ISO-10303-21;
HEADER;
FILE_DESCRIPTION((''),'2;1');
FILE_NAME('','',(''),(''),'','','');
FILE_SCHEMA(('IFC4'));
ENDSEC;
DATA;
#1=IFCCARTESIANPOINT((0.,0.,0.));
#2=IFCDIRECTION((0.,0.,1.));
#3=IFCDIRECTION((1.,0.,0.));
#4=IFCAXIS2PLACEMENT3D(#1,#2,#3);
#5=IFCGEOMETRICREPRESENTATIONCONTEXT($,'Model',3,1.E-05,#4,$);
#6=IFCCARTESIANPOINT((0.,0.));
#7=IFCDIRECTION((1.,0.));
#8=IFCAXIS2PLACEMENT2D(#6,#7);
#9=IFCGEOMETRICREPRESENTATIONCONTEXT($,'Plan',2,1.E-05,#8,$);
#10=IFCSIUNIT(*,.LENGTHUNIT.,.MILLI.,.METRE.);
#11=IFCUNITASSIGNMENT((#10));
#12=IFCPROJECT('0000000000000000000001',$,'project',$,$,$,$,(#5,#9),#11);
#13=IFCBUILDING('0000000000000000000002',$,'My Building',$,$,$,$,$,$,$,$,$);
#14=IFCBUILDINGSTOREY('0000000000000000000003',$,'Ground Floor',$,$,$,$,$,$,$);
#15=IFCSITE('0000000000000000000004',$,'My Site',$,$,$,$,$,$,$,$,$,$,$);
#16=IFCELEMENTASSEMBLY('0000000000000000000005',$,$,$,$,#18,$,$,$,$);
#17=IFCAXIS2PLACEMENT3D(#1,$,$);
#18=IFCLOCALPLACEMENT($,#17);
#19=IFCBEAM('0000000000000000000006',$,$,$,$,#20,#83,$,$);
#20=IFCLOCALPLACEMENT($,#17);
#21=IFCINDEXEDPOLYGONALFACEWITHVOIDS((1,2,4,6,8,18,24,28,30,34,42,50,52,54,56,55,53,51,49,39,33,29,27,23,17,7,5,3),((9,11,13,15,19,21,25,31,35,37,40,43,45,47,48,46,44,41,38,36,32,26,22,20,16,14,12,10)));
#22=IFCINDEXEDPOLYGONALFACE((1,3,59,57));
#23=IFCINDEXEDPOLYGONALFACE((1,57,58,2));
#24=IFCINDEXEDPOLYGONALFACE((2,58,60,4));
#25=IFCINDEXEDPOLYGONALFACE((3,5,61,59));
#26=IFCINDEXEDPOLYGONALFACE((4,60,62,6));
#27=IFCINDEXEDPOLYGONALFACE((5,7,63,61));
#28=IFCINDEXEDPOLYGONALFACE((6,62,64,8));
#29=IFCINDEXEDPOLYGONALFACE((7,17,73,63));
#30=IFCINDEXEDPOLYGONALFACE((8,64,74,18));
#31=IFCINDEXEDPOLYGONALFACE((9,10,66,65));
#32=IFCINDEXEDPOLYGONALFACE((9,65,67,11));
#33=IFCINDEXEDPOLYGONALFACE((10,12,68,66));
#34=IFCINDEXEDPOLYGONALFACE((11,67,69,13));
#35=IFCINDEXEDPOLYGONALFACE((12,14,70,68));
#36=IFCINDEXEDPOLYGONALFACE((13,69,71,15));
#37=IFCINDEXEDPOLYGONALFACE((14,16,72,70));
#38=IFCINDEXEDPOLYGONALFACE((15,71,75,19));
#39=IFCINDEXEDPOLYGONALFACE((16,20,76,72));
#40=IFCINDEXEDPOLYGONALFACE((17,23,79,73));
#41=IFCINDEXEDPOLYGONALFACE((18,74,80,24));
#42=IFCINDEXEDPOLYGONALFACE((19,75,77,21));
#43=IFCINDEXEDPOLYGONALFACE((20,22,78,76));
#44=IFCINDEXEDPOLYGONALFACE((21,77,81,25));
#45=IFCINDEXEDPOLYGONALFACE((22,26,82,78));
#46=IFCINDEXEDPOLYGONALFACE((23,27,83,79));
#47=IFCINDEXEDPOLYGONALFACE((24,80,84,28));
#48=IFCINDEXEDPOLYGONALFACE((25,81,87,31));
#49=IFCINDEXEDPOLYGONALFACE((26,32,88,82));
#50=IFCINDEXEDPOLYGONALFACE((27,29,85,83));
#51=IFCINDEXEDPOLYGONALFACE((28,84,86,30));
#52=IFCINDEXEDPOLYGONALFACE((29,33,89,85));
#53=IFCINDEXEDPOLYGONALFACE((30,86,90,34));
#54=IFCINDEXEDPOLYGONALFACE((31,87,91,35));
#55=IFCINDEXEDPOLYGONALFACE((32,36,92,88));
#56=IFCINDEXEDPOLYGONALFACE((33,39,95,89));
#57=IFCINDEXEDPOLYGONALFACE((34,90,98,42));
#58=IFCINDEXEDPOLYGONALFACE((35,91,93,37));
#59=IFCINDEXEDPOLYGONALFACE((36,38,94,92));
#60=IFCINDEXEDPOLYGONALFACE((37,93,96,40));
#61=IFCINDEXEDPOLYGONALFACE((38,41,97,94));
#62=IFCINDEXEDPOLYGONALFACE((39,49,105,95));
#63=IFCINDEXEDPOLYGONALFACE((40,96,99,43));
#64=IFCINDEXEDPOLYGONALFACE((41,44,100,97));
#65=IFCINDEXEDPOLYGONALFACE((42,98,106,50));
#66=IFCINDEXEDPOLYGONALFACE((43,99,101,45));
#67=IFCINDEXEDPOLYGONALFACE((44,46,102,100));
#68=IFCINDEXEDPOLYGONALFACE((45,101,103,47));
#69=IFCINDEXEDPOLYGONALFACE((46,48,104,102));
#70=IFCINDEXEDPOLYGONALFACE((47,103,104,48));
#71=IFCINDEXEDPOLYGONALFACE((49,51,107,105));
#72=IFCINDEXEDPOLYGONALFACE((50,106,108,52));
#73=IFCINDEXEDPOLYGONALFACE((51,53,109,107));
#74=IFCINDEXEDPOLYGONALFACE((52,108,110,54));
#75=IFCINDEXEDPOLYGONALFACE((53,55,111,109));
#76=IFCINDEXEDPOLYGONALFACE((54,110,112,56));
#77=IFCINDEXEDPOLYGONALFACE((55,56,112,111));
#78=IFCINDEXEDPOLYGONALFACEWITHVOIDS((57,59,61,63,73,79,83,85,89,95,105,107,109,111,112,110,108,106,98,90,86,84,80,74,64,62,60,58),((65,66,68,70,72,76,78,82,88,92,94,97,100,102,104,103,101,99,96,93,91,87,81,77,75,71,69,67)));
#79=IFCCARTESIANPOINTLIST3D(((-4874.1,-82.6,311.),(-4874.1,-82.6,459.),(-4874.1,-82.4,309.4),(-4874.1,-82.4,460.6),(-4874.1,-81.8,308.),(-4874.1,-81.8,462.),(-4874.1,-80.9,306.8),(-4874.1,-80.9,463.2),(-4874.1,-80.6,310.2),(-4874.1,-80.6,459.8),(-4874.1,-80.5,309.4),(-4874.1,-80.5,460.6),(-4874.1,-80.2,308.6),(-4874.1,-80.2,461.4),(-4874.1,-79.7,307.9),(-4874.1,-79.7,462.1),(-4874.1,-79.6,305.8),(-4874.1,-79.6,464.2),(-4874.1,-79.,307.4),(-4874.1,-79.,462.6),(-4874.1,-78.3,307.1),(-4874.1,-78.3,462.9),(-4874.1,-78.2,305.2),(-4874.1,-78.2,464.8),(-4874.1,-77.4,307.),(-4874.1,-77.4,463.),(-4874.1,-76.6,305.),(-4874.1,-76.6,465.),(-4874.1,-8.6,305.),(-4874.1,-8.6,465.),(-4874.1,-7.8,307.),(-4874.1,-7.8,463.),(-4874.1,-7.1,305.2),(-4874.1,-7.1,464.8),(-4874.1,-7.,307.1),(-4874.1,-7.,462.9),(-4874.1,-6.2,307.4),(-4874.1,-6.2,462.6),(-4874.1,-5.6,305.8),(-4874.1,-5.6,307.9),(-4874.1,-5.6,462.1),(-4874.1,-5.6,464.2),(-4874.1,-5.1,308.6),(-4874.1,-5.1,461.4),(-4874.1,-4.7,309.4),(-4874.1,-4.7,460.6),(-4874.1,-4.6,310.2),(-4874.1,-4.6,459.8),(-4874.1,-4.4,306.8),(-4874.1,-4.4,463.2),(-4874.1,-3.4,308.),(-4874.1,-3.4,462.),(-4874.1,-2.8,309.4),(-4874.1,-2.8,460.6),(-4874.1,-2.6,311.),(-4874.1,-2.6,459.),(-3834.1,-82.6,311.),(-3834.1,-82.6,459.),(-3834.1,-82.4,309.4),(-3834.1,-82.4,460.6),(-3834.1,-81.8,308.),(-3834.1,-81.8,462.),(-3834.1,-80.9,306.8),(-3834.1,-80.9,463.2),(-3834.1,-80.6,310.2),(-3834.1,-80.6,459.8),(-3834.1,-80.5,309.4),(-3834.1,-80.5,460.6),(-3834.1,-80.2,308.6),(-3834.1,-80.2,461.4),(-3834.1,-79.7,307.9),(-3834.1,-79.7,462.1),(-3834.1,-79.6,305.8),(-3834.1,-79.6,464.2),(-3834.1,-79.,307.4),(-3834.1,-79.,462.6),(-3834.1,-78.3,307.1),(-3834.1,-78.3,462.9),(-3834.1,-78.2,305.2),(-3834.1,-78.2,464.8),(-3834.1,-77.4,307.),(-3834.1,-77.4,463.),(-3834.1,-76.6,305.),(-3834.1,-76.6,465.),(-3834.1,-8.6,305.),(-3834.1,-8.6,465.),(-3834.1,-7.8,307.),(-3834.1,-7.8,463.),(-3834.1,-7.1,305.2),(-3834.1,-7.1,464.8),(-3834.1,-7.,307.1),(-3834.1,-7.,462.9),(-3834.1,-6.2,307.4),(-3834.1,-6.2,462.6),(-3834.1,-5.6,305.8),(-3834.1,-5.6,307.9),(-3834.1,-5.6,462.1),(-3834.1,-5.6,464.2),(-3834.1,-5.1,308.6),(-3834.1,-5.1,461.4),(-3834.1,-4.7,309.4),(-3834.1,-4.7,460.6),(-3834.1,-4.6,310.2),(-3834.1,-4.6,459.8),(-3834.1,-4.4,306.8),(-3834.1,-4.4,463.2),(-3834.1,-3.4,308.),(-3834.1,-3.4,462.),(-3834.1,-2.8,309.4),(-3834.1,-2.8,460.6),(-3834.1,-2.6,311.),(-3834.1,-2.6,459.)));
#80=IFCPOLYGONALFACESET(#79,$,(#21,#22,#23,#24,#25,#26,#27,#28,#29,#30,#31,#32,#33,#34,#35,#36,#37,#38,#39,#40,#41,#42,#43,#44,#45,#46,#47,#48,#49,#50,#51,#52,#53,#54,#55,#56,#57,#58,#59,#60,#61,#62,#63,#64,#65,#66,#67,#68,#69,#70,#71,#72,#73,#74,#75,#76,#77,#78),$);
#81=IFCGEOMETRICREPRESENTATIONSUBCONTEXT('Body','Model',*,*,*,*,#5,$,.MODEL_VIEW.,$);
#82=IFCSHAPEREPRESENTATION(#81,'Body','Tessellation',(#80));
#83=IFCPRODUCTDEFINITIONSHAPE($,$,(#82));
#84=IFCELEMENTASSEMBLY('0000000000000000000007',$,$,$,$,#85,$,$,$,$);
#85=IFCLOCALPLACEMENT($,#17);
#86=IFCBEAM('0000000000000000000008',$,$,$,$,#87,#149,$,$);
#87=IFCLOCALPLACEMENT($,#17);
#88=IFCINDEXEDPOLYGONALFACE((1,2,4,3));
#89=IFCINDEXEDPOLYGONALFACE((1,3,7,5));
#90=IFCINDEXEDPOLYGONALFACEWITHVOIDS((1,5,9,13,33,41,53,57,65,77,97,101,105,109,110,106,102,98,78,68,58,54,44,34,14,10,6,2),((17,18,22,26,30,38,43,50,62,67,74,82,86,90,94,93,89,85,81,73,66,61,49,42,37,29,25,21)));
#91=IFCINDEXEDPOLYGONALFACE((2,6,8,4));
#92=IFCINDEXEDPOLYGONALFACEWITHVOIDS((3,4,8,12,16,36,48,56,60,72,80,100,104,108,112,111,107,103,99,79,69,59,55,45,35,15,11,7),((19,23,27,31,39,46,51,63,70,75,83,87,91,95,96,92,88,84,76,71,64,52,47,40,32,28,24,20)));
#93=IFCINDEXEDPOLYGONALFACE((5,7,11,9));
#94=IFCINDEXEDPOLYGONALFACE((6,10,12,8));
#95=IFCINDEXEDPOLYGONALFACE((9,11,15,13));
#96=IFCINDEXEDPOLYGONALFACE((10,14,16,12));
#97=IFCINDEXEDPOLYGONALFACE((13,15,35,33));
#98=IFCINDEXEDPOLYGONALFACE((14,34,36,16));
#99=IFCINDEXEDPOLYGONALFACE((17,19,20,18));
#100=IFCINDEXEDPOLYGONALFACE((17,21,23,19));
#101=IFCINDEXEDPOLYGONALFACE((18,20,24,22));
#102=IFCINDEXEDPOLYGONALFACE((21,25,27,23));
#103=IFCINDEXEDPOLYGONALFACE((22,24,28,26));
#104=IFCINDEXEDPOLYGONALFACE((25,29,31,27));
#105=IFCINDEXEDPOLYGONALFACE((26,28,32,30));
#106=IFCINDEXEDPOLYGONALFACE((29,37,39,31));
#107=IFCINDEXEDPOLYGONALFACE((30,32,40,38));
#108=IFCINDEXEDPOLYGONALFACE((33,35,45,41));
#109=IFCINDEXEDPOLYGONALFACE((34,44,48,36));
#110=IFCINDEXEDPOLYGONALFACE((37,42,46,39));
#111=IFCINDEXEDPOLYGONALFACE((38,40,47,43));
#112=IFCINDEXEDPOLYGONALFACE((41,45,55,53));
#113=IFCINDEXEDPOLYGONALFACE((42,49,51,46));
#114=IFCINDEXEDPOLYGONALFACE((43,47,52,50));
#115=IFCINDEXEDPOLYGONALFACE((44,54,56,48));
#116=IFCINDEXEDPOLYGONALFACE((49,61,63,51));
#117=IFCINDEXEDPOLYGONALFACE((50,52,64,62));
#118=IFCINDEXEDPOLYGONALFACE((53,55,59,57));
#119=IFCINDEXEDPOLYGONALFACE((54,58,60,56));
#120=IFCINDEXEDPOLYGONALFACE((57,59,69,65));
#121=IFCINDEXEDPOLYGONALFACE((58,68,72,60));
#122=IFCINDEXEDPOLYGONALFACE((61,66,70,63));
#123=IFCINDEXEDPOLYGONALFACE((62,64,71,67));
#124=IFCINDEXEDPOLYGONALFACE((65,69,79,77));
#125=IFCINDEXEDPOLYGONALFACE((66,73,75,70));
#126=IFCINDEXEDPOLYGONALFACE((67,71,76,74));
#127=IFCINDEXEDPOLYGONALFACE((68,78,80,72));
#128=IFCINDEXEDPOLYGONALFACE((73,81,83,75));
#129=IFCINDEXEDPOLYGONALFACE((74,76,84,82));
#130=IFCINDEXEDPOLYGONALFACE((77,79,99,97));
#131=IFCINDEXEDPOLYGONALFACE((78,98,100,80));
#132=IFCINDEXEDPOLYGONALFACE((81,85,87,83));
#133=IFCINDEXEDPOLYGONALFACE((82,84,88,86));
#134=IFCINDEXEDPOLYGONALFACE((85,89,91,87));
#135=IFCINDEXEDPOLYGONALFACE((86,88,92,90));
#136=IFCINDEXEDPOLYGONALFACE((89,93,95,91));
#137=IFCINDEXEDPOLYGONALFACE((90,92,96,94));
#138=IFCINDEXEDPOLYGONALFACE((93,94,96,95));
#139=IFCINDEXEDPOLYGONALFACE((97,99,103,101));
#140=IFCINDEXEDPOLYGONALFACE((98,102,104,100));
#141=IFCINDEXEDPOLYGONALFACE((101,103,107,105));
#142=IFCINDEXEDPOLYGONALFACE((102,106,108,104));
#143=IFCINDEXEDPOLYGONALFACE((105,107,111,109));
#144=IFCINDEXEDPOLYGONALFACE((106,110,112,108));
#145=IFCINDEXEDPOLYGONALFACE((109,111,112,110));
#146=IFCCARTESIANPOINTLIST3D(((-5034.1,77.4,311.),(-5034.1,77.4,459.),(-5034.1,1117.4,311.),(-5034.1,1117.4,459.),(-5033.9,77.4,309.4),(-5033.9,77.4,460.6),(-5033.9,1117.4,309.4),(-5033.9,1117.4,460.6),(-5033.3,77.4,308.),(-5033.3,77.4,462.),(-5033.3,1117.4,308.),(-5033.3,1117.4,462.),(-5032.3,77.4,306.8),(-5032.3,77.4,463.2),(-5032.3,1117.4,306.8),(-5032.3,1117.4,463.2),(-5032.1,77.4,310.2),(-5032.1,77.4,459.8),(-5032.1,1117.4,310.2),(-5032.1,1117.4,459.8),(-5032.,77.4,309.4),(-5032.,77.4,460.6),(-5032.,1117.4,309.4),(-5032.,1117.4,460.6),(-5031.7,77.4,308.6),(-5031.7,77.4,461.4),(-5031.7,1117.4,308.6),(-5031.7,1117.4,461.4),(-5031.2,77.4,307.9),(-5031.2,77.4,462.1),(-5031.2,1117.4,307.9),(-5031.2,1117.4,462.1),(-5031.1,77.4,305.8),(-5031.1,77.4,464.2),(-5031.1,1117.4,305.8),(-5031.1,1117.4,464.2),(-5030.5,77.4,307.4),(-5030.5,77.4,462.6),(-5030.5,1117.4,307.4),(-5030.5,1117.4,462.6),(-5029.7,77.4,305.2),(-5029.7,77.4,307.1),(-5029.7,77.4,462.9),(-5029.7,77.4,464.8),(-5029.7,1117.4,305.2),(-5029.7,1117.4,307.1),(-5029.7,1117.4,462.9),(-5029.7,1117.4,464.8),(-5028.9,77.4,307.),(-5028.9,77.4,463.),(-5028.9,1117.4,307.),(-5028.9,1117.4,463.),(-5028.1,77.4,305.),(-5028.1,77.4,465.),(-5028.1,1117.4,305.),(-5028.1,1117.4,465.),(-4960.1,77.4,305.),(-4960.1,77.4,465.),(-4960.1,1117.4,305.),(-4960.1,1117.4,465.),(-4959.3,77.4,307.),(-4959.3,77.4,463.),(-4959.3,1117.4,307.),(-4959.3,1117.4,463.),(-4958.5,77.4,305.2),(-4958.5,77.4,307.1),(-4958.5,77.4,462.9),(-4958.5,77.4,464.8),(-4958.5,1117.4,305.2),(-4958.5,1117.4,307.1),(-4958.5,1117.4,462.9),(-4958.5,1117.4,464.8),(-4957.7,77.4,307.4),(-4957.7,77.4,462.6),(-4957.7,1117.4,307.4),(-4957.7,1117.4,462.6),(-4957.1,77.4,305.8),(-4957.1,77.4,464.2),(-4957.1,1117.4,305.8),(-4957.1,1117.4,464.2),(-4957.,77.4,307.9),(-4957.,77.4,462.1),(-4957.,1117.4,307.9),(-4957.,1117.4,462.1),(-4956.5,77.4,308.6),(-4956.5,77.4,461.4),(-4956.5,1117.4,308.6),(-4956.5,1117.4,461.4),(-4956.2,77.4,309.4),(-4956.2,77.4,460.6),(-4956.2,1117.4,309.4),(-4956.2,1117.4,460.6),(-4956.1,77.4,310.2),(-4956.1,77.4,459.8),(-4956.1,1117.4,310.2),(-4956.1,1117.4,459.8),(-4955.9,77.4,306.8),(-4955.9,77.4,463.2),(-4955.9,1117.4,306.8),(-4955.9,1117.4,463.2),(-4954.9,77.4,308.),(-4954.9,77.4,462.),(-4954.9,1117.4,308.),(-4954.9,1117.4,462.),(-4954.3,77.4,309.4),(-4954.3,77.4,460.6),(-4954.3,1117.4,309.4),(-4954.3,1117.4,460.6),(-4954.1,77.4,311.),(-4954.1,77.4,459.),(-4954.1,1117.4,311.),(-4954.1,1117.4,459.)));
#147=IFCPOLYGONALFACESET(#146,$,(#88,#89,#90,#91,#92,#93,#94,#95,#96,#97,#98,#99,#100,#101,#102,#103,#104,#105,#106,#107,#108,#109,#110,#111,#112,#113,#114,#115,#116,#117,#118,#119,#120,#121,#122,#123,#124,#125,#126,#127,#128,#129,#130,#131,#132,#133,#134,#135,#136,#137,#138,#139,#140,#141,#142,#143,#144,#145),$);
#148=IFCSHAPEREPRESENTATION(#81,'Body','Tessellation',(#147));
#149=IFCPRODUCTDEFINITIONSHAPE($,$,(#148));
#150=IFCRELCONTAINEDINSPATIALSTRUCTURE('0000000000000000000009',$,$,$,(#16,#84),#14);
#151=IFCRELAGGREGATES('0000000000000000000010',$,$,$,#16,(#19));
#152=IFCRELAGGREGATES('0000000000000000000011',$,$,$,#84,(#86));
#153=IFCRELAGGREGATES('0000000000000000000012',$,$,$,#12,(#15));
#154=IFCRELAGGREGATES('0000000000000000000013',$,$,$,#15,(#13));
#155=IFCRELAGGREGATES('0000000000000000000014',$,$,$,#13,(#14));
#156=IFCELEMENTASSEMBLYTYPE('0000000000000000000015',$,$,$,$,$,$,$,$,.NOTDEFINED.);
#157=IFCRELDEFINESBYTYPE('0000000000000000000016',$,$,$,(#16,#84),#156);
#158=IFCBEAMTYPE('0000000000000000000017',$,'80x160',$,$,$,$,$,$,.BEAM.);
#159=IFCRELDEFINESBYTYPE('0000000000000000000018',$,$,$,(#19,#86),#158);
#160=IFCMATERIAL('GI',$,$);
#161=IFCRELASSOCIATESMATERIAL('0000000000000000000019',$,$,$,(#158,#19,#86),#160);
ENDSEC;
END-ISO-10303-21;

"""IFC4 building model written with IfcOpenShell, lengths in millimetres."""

from ifc_helpers import new_model, si_unit, frame, origin_with_axes, origin_2d_with_axis, place, context, subcontext, project, spatial, hollow_rectangle, extrude, material, material_profile, profile_set, profile_usage, type_object, element, aggregate, save


model = new_model("IFC4")

# Units and contexts
model_context = context("Model", 3, precision=1e-05, world=origin_with_axes())
plan_context = context("Plan", 2, precision=1e-05, world=origin_2d_with_axis())
body_context = subcontext(model_context, "Body", "Model", "MODEL_VIEW")
ifc_project = project(units=[si_unit("LENGTHUNIT", "METRE", prefix="MILLI")], contexts=[model_context, plan_context])

# Site, building, storey
site = spatial("IfcSite", under=ifc_project, Name="My Site")
building = spatial("IfcBuilding", under=site, Name="My Building")
storey = spatial("IfcBuildingStorey", under=building, Name="Ground Floor")

# Shared definitions
ifc_material_1 = material(Name="GI")

# Element assemblies, beams
element_assembly_type_1 = type_object("IfcElementAssemblyType", PredefinedType="NOTDEFINED")
ifc_material_profile_1 = material_profile(ifc_material_1, hollow_rectangle(XDim=80.0, YDim=160.0, WallThickness=2.0, InnerFilletRadius=3.2, OuterFilletRadius=6.0))
ifc_profile_set_1 = profile_set([ifc_material_profile_1], Name="80x160 GI Rectangular Hollow")
beam_type = type_object("IfcBeamType", Name="80x160", PredefinedType="BEAM", material=ifc_profile_set_1)
assembly_1_placement = place(None, frame((-4954.1, -42.6, 385.0), z_axis=(1.0, 0.0, 0.0), x_axis=(0.0, 1.0, 0.0)))
assembly_1 = element("IfcElementAssembly", 1, at=assembly_1_placement, inside=storey, type_object=element_assembly_type_1)
ifc_profile_usage_1 = profile_usage(ifc_profile_set_1)
beam_1_placement = place(assembly_1_placement, frame((0.0, 0.0, 80.0), z_axis=(0.0, 0.0, 1.0), x_axis=(1.0, 0.0, 0.0)))
beam_1 = element("IfcBeam", 2, at=beam_1_placement, type_object=beam_type, material=ifc_profile_usage_1, context=body_context, shape_type="SweptSolid", body=[
    extrude(hollow_rectangle(XDim=80.0, YDim=160.0, WallThickness=2.0, InnerFilletRadius=3.2, OuterFilletRadius=6.0), origin_with_axes(), (0.0, 0.0, 1.0), 1040.0),
])
aggregate(assembly_1, [beam_1])
assembly_2_placement = place(None, frame((-4994.1, -2.6, 385.0), z_axis=(0.0, 1.0, 0.0), x_axis=(1.0, 0.0, 0.0)))
assembly_2 = element("IfcElementAssembly", 3, at=assembly_2_placement, inside=storey, type_object=element_assembly_type_1)
ifc_profile_usage_2 = profile_usage(ifc_profile_set_1)
beam_2_placement = place(assembly_2_placement, frame((0.0, 0.0, 80.0), z_axis=(0.0, 0.0, 1.0), x_axis=(1.0, 0.0, 0.0)))
beam_2 = element("IfcBeam", 4, at=beam_2_placement, type_object=beam_type, material=ifc_profile_usage_2, context=body_context, shape_type="SweptSolid", body=[
    extrude(hollow_rectangle(XDim=80.0, YDim=160.0, WallThickness=2.0, InnerFilletRadius=3.2, OuterFilletRadius=6.0), origin_with_axes(), (0.0, 0.0, 1.0), 1040.0),
])
aggregate(assembly_2, [beam_2])

save(model, "model.ifc")
